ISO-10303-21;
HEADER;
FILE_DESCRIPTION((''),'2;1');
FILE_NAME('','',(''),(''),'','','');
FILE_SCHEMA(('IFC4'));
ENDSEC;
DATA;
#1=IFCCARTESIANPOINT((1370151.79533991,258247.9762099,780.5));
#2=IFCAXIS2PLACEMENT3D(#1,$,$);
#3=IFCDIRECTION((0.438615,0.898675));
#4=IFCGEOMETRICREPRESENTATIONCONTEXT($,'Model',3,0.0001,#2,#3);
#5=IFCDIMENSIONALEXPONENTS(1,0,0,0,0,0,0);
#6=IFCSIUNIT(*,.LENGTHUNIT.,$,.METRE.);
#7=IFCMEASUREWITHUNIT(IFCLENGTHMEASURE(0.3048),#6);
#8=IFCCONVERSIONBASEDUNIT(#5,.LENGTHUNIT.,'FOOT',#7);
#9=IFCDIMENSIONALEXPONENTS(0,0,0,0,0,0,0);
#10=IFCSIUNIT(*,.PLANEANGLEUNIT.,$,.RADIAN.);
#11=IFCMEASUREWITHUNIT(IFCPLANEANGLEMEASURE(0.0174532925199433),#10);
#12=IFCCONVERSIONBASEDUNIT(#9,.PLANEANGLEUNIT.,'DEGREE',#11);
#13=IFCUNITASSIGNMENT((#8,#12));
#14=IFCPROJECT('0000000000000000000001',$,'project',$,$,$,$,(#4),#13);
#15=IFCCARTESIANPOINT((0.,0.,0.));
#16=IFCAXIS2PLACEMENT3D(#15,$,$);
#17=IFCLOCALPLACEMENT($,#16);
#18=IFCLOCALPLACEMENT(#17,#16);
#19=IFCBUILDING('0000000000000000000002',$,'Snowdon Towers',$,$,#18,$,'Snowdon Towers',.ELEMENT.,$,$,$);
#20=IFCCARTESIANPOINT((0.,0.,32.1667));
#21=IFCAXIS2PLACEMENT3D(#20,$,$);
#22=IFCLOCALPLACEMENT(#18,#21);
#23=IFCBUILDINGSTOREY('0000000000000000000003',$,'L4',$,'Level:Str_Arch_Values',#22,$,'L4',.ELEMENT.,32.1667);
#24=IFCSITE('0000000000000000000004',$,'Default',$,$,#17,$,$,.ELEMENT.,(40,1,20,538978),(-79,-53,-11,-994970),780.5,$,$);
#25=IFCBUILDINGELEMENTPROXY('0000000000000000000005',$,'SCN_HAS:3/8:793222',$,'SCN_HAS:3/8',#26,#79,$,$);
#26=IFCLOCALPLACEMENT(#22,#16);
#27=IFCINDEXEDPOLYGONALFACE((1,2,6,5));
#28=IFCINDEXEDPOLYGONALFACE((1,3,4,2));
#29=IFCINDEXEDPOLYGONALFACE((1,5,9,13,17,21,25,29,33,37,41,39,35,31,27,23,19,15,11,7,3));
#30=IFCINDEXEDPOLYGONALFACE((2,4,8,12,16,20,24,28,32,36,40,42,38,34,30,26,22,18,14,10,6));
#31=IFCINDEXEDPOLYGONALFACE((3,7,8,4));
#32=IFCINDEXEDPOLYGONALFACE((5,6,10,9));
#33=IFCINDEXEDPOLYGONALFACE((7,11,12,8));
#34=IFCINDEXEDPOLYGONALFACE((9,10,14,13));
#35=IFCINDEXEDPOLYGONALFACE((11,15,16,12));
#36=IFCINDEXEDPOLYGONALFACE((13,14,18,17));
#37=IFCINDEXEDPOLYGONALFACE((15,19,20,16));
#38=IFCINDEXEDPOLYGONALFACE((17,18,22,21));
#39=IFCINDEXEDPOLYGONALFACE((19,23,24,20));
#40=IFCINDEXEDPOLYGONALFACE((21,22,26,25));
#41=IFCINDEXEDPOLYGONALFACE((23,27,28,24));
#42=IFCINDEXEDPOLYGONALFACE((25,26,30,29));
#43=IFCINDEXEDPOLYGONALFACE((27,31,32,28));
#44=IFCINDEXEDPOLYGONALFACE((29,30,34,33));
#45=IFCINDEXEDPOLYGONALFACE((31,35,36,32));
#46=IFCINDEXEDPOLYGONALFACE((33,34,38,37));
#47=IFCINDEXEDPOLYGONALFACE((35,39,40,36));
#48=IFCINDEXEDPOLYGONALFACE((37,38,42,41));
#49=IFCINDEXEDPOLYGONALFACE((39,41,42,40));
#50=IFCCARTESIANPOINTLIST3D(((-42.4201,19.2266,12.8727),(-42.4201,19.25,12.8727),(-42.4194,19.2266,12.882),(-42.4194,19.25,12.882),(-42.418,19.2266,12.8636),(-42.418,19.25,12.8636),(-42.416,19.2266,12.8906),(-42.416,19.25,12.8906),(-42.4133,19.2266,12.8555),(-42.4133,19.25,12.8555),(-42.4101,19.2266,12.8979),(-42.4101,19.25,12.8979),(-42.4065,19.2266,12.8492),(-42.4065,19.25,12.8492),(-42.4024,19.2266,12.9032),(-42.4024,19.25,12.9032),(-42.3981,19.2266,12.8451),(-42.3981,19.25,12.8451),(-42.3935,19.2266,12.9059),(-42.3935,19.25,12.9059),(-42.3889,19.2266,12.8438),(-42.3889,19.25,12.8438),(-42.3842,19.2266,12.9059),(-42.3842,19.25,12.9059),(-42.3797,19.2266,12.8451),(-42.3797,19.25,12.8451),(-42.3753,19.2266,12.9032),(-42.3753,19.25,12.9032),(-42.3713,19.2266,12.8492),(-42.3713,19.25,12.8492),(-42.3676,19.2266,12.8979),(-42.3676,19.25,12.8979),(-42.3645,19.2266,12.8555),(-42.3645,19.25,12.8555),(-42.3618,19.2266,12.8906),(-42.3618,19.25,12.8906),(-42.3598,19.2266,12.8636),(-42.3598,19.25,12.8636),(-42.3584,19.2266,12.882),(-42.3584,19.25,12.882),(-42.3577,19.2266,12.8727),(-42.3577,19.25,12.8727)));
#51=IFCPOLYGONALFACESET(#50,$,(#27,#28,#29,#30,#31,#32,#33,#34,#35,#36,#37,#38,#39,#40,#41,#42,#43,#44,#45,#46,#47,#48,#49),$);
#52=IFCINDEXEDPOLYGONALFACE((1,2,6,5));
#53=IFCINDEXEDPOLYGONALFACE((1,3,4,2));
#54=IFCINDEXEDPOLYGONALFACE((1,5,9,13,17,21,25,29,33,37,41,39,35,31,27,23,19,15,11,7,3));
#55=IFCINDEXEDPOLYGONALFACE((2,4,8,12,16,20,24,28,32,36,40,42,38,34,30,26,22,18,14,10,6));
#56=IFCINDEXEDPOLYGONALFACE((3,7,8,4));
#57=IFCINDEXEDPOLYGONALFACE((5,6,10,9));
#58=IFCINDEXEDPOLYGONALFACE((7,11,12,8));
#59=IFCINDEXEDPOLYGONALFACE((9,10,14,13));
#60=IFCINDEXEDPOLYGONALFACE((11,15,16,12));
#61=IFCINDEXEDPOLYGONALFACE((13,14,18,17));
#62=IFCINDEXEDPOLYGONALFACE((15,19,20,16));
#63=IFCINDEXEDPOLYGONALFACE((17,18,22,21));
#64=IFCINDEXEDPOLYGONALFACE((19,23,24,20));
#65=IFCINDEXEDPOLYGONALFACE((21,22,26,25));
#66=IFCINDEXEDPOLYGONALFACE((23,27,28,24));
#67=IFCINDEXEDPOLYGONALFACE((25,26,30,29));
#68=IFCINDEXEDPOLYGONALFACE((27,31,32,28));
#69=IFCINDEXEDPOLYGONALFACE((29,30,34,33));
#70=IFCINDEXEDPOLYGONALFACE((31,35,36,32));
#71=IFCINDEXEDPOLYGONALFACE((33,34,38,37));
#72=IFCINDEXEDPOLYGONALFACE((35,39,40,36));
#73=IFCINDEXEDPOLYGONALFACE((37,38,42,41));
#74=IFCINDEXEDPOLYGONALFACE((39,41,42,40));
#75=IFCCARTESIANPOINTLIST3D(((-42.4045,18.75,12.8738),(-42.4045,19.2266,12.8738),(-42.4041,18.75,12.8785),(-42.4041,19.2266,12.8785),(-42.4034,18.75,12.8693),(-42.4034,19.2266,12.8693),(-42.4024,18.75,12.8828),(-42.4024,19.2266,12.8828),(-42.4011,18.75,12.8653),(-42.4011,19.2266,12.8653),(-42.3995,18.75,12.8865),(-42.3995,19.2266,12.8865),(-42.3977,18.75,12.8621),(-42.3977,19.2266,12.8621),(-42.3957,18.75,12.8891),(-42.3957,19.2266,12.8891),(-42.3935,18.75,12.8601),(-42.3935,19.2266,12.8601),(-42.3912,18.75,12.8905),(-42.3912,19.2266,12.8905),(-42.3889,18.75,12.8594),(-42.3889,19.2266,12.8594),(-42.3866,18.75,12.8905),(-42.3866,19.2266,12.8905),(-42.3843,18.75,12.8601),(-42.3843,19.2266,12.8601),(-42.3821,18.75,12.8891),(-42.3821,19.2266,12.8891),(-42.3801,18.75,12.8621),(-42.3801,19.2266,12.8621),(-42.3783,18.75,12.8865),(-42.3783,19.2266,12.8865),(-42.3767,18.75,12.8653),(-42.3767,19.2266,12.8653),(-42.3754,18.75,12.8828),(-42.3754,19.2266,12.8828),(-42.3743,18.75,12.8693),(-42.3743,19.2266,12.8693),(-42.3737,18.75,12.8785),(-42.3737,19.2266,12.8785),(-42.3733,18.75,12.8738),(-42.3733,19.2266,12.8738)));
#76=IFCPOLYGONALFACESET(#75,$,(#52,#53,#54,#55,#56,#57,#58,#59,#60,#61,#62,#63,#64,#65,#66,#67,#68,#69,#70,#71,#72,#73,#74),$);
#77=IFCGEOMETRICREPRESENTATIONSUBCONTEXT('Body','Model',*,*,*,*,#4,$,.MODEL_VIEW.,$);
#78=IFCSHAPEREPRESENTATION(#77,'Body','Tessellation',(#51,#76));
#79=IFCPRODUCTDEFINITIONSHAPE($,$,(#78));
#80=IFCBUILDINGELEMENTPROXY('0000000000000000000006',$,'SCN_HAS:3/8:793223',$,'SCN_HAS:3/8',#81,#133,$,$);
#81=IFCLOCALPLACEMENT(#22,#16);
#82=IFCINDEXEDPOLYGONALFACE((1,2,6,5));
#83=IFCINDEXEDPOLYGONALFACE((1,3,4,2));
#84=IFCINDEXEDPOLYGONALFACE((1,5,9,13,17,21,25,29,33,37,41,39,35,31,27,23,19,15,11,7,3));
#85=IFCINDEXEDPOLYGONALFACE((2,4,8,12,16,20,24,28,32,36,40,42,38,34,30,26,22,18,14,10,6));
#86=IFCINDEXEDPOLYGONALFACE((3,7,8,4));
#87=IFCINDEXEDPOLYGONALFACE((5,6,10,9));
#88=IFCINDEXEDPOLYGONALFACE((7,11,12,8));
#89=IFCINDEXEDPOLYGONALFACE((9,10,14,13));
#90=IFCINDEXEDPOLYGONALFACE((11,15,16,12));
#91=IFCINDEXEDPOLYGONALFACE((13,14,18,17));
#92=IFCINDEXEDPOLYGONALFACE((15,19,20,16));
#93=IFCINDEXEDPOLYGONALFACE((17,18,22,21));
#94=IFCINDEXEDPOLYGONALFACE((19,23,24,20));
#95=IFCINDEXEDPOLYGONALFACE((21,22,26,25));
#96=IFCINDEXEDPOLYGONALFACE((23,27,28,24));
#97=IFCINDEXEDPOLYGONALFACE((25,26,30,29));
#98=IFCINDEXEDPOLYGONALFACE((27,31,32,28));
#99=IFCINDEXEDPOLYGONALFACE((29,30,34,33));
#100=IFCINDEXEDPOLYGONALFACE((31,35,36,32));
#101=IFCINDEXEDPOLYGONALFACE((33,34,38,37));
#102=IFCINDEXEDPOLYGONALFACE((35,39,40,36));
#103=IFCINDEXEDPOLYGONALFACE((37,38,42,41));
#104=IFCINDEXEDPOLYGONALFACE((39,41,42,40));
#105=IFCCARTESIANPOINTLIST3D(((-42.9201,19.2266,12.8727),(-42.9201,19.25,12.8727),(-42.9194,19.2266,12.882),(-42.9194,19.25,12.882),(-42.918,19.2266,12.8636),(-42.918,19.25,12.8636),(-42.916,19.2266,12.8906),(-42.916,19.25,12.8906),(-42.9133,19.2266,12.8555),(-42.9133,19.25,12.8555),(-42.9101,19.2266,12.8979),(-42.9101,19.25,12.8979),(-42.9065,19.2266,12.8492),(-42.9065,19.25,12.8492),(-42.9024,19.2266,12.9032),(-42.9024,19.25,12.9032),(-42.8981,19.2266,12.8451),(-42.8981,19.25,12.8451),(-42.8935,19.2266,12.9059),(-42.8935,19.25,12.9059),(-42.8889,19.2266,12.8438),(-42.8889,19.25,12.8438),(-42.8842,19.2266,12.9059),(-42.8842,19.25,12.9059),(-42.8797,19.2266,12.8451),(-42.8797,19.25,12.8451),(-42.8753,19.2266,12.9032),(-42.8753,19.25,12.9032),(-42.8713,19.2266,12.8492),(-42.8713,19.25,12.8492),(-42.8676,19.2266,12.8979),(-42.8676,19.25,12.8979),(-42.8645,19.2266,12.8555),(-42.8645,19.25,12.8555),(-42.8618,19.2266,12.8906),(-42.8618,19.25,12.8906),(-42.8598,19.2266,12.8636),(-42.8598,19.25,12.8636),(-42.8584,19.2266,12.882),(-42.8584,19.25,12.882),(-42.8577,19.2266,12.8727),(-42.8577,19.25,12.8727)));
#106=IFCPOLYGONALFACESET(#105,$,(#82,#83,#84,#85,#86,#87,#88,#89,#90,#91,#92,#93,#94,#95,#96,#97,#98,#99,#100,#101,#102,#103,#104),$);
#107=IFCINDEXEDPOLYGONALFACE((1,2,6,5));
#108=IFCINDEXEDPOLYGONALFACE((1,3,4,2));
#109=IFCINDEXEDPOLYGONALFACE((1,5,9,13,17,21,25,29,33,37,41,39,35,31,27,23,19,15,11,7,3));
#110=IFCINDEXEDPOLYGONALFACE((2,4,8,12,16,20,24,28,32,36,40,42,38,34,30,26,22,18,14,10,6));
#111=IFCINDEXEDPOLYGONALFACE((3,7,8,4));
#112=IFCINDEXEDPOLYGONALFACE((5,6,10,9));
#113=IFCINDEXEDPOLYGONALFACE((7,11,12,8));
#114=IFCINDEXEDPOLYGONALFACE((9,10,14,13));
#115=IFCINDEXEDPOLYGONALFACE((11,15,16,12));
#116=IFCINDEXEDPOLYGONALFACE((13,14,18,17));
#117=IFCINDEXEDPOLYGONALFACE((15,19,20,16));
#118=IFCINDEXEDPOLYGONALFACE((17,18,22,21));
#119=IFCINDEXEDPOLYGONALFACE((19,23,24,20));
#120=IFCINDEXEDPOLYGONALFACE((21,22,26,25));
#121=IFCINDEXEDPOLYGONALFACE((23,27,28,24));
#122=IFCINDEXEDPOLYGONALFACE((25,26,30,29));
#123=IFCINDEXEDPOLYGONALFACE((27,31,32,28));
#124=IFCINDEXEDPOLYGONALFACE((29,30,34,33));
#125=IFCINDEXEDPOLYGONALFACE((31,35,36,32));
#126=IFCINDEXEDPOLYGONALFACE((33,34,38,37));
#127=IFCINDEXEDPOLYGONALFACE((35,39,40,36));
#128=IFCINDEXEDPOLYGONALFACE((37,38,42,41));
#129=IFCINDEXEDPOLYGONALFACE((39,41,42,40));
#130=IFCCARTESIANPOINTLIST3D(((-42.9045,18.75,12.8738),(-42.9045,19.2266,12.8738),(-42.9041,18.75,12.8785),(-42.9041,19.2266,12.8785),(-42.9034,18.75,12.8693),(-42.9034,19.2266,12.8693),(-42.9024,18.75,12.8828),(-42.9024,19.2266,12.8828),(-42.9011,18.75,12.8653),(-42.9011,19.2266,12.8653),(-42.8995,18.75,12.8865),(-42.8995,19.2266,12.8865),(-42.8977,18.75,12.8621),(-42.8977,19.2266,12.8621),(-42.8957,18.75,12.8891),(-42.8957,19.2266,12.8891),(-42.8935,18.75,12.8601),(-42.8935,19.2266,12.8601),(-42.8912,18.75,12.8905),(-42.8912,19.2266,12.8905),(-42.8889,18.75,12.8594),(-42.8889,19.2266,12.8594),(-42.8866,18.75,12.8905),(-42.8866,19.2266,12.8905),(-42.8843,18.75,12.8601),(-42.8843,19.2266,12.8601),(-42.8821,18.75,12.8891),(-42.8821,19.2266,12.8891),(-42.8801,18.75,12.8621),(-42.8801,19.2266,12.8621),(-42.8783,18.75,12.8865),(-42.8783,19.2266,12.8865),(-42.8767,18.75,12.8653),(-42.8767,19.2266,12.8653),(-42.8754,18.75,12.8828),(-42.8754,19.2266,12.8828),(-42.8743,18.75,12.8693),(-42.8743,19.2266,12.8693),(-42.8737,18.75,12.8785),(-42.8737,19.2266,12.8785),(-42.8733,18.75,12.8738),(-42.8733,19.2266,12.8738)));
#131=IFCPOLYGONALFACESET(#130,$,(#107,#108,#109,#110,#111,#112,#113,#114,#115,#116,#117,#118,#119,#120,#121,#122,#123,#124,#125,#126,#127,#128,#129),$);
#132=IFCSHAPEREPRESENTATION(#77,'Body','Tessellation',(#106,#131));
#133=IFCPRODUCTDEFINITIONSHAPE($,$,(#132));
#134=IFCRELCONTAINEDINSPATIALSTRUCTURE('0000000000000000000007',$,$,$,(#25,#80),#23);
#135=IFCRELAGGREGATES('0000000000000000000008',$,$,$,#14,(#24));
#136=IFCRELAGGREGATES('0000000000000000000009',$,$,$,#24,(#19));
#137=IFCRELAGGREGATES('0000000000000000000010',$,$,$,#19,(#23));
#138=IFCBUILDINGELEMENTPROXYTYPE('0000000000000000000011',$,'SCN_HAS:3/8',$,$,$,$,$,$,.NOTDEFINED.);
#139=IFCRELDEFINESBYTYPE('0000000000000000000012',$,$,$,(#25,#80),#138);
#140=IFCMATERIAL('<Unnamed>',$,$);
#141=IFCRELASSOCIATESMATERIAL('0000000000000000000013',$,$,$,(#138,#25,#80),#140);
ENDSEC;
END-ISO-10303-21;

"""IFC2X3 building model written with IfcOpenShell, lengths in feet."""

from ifc_helpers import new_model, entity, si_unit, converted_unit, direction, frame, frame_2d, origin, place, context, subcontext, project, spatial, circle, extrude, source, transform, mapped, material, type_object, type_shapes, element, save


model = new_model("IFC2X3")

# Units and contexts
model_context = context("Model", 3, precision=0.0001, world=frame((1370151.79533991, 258247.9762099, 780.5)), true_north=direction((0.438615, 0.898675)))
body_context = subcontext(model_context, "Body", "Model", "MODEL_VIEW")
ifc_project = project(units=[converted_unit("LENGTHUNIT", "FOOT", entity("IfcLengthMeasure", 0.3048), si_unit("LENGTHUNIT", "METRE"), dimensions=[1, 0, 0, 0, 0, 0, 0]), converted_unit("PLANEANGLEUNIT", "DEGREE", entity("IfcPlaneAngleMeasure", 0.0174532925199433), si_unit("PLANEANGLEUNIT", "RADIAN"), dimensions=[0, 0, 0, 0, 0, 0, 0])], contexts=[model_context])

# Site, building, storey
site_placement = place(None, origin())
site = spatial("IfcSite", under=ifc_project, at=site_placement, Name="Default", CompositionType="ELEMENT", RefLatitude=(40, 1, 20, 538978), RefLongitude=(-79, -53, -11, -994970), RefElevation=780.5)
building_placement = place(site_placement, origin())
building = spatial("IfcBuilding", under=site, at=building_placement, Name="Snowdon Towers", LongName="Snowdon Towers", CompositionType="ELEMENT")
storey_placement = place(building_placement, frame((0.0, 0.0, 32.1667)))
storey = spatial("IfcBuildingStorey", under=building, at=storey_placement, Name="L4", ObjectType="Level:Str_Arch_Values", LongName="L4", CompositionType="ELEMENT", Elevation=32.1667)

# Building element proxies
ifc_material_1 = material(Name="<Unnamed>")
building_element_proxy_type = type_object("IfcBuildingElementProxyType", Name="SCN_HAS:3/8", PredefinedType="NOTDEFINED", material=ifc_material_1)
shared_shape = source(origin(), body_context, "Body", "SweptSolid", [
    extrude(circle(Radius=0.0312, at=frame_2d((0.0, 0.0), x_axis=(1.0, 0.0))), frame((0.0, 0.0, -0.5), z_axis=(0.0, 0.0, 1.0), x_axis=(0.0, -1.0, 0.0)), (0.0, 0.0, 1.0), 0.0234),
    extrude(circle(Radius=0.0156, at=frame_2d((0.0, 0.0), x_axis=(1.0, 0.0))), frame((0.0, 0.0, -0.4766), z_axis=(0.0, 0.0, 1.0), x_axis=(0.0, -1.0, 0.0)), (0.0, 0.0, 1.0), 0.4766),
])
type_shapes(building_element_proxy_type, [shared_shape])
for number, where, z_axis, x_axis, name in (
    (1, (-42.3889, 18.75, 12.875), (0.0, -1.0, 0.0), (1.0, 0.0, 0.0), "SCN_HAS:3/8:793222"),
    (2, (-42.8889, 18.75, 12.875), (0.0, -1.0, 0.0), (1.0, 0.0, 0.0), "SCN_HAS:3/8:793223"),
):
    element("IfcBuildingElementProxy", number, at=place(storey_placement, frame(where, z_axis=z_axis, x_axis=x_axis)), inside=storey, type_object=building_element_proxy_type, material=ifc_material_1, Name=name, ObjectType="SCN_HAS:3/8", context=body_context, shape_type="MappedRepresentation", body=[
        mapped(shared_shape, transform((0.0, 0.0, 0.0), scale=1.0)),
    ])

save(model, "model.ifc")
